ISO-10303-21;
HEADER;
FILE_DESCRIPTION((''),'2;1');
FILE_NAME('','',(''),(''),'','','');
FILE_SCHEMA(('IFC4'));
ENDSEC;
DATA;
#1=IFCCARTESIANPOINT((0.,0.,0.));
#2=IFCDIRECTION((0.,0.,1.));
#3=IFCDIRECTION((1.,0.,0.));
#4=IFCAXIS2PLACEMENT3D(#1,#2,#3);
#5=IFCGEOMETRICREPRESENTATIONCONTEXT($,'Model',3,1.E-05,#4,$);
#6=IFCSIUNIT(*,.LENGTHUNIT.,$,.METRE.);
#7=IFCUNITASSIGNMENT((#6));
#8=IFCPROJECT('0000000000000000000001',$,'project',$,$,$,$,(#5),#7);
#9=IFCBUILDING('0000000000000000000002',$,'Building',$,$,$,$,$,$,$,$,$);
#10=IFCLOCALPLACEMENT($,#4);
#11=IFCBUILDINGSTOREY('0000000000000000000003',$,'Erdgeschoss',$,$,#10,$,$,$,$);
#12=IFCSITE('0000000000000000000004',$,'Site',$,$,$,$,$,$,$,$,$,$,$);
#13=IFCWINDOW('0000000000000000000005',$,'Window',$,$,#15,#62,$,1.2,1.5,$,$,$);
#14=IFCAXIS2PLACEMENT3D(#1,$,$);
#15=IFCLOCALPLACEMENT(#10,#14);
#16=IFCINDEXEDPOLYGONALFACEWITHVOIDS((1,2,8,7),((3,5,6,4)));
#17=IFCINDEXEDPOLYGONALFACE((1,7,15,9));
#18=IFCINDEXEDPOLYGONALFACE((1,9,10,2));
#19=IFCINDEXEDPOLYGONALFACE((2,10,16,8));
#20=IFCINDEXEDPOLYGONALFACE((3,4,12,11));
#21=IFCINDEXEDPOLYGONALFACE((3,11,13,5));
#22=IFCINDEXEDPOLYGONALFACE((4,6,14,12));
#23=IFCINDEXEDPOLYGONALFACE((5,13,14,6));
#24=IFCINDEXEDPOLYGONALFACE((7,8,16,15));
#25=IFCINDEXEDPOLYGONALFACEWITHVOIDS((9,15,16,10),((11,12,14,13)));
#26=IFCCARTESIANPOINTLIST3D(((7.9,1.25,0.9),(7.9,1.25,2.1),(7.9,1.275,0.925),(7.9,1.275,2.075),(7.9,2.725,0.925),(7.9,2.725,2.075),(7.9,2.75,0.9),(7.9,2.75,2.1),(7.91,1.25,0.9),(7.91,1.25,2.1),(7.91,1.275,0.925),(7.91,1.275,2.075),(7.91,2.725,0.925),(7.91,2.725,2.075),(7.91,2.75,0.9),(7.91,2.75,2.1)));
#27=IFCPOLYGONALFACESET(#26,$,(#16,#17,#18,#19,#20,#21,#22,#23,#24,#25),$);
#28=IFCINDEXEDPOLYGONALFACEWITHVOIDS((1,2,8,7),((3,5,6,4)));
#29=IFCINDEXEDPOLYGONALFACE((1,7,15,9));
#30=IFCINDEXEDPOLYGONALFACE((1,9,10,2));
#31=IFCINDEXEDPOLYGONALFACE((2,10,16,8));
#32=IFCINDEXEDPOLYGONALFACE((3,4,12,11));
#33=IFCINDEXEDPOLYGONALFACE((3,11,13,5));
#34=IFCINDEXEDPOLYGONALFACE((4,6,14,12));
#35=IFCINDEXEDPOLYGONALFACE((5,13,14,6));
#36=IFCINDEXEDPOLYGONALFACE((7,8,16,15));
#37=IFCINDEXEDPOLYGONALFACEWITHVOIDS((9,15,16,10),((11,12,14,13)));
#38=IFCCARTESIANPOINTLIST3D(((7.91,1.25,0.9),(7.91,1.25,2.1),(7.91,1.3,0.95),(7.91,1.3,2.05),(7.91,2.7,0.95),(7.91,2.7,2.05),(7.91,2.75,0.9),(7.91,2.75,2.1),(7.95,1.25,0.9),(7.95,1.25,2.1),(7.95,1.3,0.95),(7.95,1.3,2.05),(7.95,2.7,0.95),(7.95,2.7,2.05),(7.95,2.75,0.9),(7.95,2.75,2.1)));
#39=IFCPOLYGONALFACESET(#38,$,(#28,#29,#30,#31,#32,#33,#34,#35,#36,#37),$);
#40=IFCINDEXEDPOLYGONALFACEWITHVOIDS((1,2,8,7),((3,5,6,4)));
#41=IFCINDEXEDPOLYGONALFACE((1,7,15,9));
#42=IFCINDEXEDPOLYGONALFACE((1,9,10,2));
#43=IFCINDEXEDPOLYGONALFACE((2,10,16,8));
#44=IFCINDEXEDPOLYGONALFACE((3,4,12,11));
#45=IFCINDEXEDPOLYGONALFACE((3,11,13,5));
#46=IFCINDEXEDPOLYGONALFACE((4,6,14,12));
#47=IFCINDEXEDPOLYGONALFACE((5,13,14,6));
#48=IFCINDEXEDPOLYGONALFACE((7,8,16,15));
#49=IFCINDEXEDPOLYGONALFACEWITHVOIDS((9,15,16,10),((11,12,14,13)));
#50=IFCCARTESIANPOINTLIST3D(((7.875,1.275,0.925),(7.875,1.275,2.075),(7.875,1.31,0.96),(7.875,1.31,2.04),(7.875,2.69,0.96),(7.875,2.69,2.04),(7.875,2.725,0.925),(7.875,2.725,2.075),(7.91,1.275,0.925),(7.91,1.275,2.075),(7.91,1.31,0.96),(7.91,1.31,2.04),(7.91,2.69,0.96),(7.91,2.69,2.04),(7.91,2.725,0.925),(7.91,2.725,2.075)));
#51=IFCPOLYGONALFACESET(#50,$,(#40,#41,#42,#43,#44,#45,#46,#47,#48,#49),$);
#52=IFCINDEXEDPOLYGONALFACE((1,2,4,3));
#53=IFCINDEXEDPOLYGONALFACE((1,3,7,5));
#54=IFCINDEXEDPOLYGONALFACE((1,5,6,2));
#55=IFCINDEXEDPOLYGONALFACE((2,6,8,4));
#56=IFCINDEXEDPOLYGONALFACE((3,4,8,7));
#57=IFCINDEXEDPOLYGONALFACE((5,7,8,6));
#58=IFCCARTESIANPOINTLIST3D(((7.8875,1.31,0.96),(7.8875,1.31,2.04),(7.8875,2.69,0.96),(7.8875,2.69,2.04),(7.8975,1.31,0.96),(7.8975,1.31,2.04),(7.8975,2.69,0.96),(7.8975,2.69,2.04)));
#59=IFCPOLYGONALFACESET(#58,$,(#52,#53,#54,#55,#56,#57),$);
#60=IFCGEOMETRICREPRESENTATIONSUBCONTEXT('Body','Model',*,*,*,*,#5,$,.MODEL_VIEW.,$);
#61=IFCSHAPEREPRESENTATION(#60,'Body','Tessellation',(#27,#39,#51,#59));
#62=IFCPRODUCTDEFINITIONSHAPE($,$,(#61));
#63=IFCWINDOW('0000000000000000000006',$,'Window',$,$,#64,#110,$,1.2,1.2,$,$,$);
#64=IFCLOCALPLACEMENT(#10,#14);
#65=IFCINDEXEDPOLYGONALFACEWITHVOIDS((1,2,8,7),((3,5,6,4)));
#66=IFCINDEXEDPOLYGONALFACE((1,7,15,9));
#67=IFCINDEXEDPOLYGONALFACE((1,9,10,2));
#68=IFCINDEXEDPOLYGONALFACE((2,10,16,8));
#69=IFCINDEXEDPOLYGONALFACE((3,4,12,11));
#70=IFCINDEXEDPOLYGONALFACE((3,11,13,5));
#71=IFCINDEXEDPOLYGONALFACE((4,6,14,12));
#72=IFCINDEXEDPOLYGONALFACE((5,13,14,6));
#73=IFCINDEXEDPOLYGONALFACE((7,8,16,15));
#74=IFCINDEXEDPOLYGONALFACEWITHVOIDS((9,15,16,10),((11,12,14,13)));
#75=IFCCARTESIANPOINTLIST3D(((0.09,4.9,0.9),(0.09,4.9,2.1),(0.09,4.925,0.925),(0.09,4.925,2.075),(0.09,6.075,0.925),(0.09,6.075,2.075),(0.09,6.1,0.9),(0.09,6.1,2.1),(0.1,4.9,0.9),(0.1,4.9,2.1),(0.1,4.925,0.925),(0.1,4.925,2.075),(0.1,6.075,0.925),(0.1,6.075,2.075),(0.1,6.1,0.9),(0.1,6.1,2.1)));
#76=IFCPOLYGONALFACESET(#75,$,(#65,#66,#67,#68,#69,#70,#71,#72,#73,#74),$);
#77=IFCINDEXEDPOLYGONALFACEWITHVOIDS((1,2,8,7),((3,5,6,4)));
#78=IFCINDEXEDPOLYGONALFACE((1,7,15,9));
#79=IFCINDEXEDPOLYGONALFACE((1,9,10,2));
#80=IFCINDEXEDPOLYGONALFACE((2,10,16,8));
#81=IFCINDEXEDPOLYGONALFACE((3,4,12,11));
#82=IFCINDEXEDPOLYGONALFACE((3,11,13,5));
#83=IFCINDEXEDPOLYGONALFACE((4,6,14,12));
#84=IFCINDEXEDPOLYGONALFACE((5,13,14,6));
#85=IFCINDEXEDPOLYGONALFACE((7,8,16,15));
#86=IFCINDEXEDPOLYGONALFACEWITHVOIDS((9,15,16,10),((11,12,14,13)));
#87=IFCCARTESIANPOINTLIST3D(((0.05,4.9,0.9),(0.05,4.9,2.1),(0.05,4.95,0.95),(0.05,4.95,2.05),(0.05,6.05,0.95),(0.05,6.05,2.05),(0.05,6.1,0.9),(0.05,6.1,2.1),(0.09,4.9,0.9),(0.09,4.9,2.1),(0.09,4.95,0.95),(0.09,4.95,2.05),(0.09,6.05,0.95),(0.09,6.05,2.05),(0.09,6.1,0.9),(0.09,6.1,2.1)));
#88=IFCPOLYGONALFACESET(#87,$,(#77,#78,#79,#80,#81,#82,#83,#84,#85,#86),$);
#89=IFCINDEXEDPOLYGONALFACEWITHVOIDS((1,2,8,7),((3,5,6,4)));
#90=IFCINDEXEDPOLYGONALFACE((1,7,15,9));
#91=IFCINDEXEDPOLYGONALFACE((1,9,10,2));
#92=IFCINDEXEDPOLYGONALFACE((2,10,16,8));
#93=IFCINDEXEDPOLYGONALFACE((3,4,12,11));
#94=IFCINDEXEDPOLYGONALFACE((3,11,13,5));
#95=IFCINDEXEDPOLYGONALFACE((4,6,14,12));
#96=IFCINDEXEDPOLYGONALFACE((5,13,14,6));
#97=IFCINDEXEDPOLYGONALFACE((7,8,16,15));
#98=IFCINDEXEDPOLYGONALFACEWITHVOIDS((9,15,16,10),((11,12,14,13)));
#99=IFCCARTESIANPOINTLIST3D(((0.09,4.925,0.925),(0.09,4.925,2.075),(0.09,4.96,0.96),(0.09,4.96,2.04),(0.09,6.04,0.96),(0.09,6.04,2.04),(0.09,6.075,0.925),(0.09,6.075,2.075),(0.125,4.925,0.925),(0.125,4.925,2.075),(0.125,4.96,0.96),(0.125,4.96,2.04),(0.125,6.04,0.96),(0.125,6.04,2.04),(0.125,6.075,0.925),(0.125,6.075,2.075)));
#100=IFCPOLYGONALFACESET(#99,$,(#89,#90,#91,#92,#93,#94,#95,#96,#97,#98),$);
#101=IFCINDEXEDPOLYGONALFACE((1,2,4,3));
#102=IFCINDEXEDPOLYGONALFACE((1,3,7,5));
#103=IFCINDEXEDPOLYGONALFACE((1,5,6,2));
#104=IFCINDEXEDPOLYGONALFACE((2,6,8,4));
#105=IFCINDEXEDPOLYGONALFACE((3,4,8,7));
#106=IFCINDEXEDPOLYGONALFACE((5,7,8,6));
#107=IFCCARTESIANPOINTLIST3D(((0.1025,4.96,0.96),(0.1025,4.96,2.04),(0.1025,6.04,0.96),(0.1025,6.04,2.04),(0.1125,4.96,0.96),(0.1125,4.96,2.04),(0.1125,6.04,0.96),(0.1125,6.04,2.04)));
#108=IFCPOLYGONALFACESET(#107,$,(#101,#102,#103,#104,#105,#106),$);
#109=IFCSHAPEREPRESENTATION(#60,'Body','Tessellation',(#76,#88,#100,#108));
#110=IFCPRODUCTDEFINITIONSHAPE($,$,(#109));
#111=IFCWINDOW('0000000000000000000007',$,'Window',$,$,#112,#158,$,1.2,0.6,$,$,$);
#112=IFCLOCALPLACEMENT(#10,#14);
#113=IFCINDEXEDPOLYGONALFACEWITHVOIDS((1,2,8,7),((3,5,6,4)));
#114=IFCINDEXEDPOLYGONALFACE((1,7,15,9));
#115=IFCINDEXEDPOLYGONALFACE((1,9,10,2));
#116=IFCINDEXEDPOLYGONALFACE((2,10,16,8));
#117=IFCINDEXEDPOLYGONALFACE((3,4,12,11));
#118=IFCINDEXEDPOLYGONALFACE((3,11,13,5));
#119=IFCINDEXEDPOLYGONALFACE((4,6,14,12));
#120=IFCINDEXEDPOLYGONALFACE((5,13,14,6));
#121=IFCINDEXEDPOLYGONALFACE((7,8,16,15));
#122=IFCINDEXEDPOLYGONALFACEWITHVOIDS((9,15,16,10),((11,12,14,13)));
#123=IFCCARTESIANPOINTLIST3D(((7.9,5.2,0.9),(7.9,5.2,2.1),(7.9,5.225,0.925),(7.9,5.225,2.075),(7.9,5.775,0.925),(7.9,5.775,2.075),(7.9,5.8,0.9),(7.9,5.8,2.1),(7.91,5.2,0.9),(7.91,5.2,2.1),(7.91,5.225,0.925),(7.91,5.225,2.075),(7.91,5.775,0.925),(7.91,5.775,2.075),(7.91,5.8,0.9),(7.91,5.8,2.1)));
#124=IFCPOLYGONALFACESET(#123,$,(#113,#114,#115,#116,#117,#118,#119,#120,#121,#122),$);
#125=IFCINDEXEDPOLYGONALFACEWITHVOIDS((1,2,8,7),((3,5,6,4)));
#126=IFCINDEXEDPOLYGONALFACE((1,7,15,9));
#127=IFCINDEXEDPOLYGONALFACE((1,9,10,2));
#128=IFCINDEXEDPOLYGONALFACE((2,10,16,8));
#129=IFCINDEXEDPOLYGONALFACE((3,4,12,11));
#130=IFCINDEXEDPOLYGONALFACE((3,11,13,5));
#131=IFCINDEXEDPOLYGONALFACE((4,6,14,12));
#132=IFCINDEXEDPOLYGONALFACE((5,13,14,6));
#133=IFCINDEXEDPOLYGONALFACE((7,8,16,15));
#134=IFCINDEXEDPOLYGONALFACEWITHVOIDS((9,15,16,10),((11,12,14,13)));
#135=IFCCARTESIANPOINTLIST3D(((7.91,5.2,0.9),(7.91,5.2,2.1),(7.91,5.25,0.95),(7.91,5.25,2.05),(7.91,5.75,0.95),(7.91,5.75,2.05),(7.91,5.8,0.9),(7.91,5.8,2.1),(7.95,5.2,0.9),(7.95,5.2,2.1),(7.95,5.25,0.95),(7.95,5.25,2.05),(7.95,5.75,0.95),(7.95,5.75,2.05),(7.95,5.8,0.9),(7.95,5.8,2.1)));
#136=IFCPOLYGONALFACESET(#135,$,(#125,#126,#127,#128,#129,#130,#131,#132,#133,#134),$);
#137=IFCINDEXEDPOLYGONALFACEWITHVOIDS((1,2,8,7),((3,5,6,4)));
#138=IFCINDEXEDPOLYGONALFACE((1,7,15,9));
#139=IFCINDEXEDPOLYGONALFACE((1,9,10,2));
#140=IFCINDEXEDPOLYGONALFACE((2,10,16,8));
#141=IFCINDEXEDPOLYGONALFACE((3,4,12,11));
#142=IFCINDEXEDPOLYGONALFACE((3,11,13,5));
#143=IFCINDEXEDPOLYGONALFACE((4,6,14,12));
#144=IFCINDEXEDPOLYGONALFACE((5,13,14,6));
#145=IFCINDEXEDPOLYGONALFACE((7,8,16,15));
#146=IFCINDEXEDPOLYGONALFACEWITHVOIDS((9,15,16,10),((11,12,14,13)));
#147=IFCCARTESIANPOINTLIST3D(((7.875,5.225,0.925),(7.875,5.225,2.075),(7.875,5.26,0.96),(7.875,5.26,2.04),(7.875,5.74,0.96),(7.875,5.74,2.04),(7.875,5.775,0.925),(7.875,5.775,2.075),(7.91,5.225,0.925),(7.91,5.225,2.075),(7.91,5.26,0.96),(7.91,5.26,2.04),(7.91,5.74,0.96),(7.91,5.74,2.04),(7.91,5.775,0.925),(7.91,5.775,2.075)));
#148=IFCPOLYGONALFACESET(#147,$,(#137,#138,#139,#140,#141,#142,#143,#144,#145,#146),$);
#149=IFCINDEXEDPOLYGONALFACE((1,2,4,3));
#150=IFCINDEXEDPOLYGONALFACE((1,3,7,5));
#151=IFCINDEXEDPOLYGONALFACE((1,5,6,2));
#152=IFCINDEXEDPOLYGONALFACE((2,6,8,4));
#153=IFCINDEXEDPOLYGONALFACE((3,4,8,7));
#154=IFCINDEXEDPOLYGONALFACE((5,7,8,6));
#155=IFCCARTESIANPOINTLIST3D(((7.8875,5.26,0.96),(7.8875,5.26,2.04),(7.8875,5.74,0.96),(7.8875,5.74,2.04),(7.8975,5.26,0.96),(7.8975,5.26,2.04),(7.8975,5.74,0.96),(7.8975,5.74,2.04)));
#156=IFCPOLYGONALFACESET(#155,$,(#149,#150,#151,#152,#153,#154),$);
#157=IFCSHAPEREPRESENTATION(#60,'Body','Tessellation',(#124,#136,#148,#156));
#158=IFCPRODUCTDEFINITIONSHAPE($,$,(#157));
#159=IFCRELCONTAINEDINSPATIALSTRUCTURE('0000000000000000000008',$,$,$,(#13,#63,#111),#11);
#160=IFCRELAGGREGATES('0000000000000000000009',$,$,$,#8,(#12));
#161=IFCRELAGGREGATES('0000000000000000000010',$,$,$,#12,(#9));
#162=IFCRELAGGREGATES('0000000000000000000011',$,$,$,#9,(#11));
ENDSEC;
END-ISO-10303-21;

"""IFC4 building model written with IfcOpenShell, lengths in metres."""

from ifc_helpers import new_model, si_unit, frame, origin_with_axes, place, context, subcontext, project, spatial, line, indexed_curve, outline, extrude, element, save


model = new_model("IFC4")

# Units and contexts
model_context = context("Model", 3, precision=1e-05, world=origin_with_axes())
body_context = subcontext(model_context, "Body", "Model", "MODEL_VIEW")
ifc_project = project(units=[si_unit("LENGTHUNIT", "METRE")], contexts=[model_context])

# Site, building, storey
site = spatial("IfcSite", under=ifc_project, Name="Site")
building = spatial("IfcBuilding", under=site, Name="Building")
storey_placement = place(None, origin_with_axes())
storey = spatial("IfcBuildingStorey", under=building, at=storey_placement, Name="Erdgeschoss")

# Windows
for number, where, z_axis, x_axis, name in (
    (1, (8.0, 1.25, 0.9), (0.0, 0.0, 1.0), (0.0, 1.0, 0.0), "Window"),
):
    element("IfcWindow", number, at=place(storey_placement, frame(where, z_axis=z_axis, x_axis=x_axis)), inside=storey, Name=name, OverallHeight=1.2, OverallWidth=1.5, context=body_context, shape_type="SweptSolid", body=[
        extrude(outline(indexed_curve([(0.0, 0.0), (1.5, 0.0), (1.5, 1.2), (0.0, 1.2)], segments=[line(1, 2, 3, 4, 1)]), holes=[indexed_curve([(0.025, 0.025), (1.475, 0.025), (1.475, 1.175), (0.025, 1.175)], segments=[line(1, 2, 3, 4, 1)])]), frame((0.0, 0.09, 0.0), z_axis=(0.0, -1.0, 0.0), x_axis=(1.0, 0.0, 0.0)), (0.0, 0.0, -1.0), 0.01),
        extrude(outline(indexed_curve([(0.0, 0.0), (1.5, 0.0), (1.5, 1.2), (0.0, 1.2)], segments=[line(1, 2, 3, 4, 1)]), holes=[indexed_curve([(0.05, 0.05), (1.45, 0.05), (1.45, 1.15), (0.05, 1.15)], segments=[line(1, 2, 3, 4, 1)])]), frame((0.0, 0.05, 0.0), z_axis=(0.0, -1.0, 0.0), x_axis=(1.0, 0.0, 0.0)), (0.0, 0.0, -1.0), 0.04),
        extrude(outline(indexed_curve([(0.0, 0.0), (1.45, 0.0), (1.45, 1.15), (0.0, 1.15)], segments=[line(1, 2, 3, 4, 1)]), holes=[indexed_curve([(0.035, 0.035), (1.415, 0.035), (1.415, 1.115), (0.035, 1.115)], segments=[line(1, 2, 3, 4, 1)])]), frame((0.025, 0.09, 0.025), z_axis=(0.0, -1.0, 0.0), x_axis=(1.0, 0.0, 0.0)), (0.0, 0.0, -1.0), 0.035),
        extrude(outline(indexed_curve([(0.035, 0.035), (1.415, 0.035), (1.415, 1.115), (0.035, 1.115)], segments=[line(1, 2, 3, 4, 1)])), frame((0.025, 0.1025, 0.025), z_axis=(0.0, -1.0, 0.0), x_axis=(1.0, 0.0, 0.0)), (0.0, 0.0, -1.0), 0.01),
    ])
window_1_placement = place(storey_placement, frame((0.0, 6.1, 0.9), z_axis=(0.0, 0.0, 1.0), x_axis=(0.0, -1.0, 0.0)))
element("IfcWindow", 2, at=window_1_placement, inside=storey, Name="Window", OverallHeight=1.2, OverallWidth=1.2, context=body_context, shape_type="SweptSolid", body=[
    extrude(outline(indexed_curve([(0.0, 0.0), (1.2, 0.0), (1.2, 1.2), (0.0, 1.2)], segments=[line(1, 2, 3, 4, 1)]), holes=[indexed_curve([(0.025, 0.025), (1.175, 0.025), (1.175, 1.175), (0.025, 1.175)], segments=[line(1, 2, 3, 4, 1)])]), frame((0.0, 0.09, 0.0), z_axis=(0.0, -1.0, 0.0), x_axis=(1.0, 0.0, 0.0)), (0.0, 0.0, -1.0), 0.01),
    extrude(outline(indexed_curve([(0.0, 0.0), (1.2, 0.0), (1.2, 1.2), (0.0, 1.2)], segments=[line(1, 2, 3, 4, 1)]), holes=[indexed_curve([(0.05, 0.05), (1.15, 0.05), (1.15, 1.15), (0.05, 1.15)], segments=[line(1, 2, 3, 4, 1)])]), frame((0.0, 0.05, 0.0), z_axis=(0.0, -1.0, 0.0), x_axis=(1.0, 0.0, 0.0)), (0.0, 0.0, -1.0), 0.04),
    extrude(outline(indexed_curve([(0.0, 0.0), (1.15, 0.0), (1.15, 1.15), (0.0, 1.15)], segments=[line(1, 2, 3, 4, 1)]), holes=[indexed_curve([(0.035, 0.035), (1.115, 0.035), (1.115, 1.115), (0.035, 1.115)], segments=[line(1, 2, 3, 4, 1)])]), frame((0.025, 0.09, 0.025), z_axis=(0.0, -1.0, 0.0), x_axis=(1.0, 0.0, 0.0)), (0.0, 0.0, -1.0), 0.035),
    extrude(outline(indexed_curve([(0.035, 0.035), (1.115, 0.035), (1.115, 1.115), (0.035, 1.115)], segments=[line(1, 2, 3, 4, 1)])), frame((0.025, 0.1025, 0.025), z_axis=(0.0, -1.0, 0.0), x_axis=(1.0, 0.0, 0.0)), (0.0, 0.0, -1.0), 0.01),
])
window_2_placement = place(storey_placement, frame((8.0, 5.2, 0.9), z_axis=(0.0, 0.0, 1.0), x_axis=(0.0, 1.0, 0.0)))
element("IfcWindow", 3, at=window_2_placement, inside=storey, Name="Window", OverallHeight=1.2, OverallWidth=0.6, context=body_context, shape_type="SweptSolid", body=[
    extrude(outline(indexed_curve([(0.0, 0.0), (0.6, 0.0), (0.6, 1.2), (0.0, 1.2)], segments=[line(1, 2, 3, 4, 1)]), holes=[indexed_curve([(0.025, 0.025), (0.575, 0.025), (0.575, 1.175), (0.025, 1.175)], segments=[line(1, 2, 3, 4, 1)])]), frame((0.0, 0.09, 0.0), z_axis=(0.0, -1.0, 0.0), x_axis=(1.0, 0.0, 0.0)), (0.0, 0.0, -1.0), 0.01),
    extrude(outline(indexed_curve([(0.0, 0.0), (0.6, 0.0), (0.6, 1.2), (0.0, 1.2)], segments=[line(1, 2, 3, 4, 1)]), holes=[indexed_curve([(0.05, 0.05), (0.55, 0.05), (0.55, 1.15), (0.05, 1.15)], segments=[line(1, 2, 3, 4, 1)])]), frame((0.0, 0.05, 0.0), z_axis=(0.0, -1.0, 0.0), x_axis=(1.0, 0.0, 0.0)), (0.0, 0.0, -1.0), 0.04),
    extrude(outline(indexed_curve([(0.0, 0.0), (0.55, 0.0), (0.55, 1.15), (0.0, 1.15)], segments=[line(1, 2, 3, 4, 1)]), holes=[indexed_curve([(0.035, 0.035), (0.515, 0.035), (0.515, 1.115), (0.035, 1.115)], segments=[line(1, 2, 3, 4, 1)])]), frame((0.025, 0.09, 0.025), z_axis=(0.0, -1.0, 0.0), x_axis=(1.0, 0.0, 0.0)), (0.0, 0.0, -1.0), 0.035),
    extrude(outline(indexed_curve([(0.035, 0.035), (0.515, 0.035), (0.515, 1.115), (0.035, 1.115)], segments=[line(1, 2, 3, 4, 1)])), frame((0.025, 0.1025, 0.025), z_axis=(0.0, -1.0, 0.0), x_axis=(1.0, 0.0, 0.0)), (0.0, 0.0, -1.0), 0.01),
])

save(model, "model.ifc")
